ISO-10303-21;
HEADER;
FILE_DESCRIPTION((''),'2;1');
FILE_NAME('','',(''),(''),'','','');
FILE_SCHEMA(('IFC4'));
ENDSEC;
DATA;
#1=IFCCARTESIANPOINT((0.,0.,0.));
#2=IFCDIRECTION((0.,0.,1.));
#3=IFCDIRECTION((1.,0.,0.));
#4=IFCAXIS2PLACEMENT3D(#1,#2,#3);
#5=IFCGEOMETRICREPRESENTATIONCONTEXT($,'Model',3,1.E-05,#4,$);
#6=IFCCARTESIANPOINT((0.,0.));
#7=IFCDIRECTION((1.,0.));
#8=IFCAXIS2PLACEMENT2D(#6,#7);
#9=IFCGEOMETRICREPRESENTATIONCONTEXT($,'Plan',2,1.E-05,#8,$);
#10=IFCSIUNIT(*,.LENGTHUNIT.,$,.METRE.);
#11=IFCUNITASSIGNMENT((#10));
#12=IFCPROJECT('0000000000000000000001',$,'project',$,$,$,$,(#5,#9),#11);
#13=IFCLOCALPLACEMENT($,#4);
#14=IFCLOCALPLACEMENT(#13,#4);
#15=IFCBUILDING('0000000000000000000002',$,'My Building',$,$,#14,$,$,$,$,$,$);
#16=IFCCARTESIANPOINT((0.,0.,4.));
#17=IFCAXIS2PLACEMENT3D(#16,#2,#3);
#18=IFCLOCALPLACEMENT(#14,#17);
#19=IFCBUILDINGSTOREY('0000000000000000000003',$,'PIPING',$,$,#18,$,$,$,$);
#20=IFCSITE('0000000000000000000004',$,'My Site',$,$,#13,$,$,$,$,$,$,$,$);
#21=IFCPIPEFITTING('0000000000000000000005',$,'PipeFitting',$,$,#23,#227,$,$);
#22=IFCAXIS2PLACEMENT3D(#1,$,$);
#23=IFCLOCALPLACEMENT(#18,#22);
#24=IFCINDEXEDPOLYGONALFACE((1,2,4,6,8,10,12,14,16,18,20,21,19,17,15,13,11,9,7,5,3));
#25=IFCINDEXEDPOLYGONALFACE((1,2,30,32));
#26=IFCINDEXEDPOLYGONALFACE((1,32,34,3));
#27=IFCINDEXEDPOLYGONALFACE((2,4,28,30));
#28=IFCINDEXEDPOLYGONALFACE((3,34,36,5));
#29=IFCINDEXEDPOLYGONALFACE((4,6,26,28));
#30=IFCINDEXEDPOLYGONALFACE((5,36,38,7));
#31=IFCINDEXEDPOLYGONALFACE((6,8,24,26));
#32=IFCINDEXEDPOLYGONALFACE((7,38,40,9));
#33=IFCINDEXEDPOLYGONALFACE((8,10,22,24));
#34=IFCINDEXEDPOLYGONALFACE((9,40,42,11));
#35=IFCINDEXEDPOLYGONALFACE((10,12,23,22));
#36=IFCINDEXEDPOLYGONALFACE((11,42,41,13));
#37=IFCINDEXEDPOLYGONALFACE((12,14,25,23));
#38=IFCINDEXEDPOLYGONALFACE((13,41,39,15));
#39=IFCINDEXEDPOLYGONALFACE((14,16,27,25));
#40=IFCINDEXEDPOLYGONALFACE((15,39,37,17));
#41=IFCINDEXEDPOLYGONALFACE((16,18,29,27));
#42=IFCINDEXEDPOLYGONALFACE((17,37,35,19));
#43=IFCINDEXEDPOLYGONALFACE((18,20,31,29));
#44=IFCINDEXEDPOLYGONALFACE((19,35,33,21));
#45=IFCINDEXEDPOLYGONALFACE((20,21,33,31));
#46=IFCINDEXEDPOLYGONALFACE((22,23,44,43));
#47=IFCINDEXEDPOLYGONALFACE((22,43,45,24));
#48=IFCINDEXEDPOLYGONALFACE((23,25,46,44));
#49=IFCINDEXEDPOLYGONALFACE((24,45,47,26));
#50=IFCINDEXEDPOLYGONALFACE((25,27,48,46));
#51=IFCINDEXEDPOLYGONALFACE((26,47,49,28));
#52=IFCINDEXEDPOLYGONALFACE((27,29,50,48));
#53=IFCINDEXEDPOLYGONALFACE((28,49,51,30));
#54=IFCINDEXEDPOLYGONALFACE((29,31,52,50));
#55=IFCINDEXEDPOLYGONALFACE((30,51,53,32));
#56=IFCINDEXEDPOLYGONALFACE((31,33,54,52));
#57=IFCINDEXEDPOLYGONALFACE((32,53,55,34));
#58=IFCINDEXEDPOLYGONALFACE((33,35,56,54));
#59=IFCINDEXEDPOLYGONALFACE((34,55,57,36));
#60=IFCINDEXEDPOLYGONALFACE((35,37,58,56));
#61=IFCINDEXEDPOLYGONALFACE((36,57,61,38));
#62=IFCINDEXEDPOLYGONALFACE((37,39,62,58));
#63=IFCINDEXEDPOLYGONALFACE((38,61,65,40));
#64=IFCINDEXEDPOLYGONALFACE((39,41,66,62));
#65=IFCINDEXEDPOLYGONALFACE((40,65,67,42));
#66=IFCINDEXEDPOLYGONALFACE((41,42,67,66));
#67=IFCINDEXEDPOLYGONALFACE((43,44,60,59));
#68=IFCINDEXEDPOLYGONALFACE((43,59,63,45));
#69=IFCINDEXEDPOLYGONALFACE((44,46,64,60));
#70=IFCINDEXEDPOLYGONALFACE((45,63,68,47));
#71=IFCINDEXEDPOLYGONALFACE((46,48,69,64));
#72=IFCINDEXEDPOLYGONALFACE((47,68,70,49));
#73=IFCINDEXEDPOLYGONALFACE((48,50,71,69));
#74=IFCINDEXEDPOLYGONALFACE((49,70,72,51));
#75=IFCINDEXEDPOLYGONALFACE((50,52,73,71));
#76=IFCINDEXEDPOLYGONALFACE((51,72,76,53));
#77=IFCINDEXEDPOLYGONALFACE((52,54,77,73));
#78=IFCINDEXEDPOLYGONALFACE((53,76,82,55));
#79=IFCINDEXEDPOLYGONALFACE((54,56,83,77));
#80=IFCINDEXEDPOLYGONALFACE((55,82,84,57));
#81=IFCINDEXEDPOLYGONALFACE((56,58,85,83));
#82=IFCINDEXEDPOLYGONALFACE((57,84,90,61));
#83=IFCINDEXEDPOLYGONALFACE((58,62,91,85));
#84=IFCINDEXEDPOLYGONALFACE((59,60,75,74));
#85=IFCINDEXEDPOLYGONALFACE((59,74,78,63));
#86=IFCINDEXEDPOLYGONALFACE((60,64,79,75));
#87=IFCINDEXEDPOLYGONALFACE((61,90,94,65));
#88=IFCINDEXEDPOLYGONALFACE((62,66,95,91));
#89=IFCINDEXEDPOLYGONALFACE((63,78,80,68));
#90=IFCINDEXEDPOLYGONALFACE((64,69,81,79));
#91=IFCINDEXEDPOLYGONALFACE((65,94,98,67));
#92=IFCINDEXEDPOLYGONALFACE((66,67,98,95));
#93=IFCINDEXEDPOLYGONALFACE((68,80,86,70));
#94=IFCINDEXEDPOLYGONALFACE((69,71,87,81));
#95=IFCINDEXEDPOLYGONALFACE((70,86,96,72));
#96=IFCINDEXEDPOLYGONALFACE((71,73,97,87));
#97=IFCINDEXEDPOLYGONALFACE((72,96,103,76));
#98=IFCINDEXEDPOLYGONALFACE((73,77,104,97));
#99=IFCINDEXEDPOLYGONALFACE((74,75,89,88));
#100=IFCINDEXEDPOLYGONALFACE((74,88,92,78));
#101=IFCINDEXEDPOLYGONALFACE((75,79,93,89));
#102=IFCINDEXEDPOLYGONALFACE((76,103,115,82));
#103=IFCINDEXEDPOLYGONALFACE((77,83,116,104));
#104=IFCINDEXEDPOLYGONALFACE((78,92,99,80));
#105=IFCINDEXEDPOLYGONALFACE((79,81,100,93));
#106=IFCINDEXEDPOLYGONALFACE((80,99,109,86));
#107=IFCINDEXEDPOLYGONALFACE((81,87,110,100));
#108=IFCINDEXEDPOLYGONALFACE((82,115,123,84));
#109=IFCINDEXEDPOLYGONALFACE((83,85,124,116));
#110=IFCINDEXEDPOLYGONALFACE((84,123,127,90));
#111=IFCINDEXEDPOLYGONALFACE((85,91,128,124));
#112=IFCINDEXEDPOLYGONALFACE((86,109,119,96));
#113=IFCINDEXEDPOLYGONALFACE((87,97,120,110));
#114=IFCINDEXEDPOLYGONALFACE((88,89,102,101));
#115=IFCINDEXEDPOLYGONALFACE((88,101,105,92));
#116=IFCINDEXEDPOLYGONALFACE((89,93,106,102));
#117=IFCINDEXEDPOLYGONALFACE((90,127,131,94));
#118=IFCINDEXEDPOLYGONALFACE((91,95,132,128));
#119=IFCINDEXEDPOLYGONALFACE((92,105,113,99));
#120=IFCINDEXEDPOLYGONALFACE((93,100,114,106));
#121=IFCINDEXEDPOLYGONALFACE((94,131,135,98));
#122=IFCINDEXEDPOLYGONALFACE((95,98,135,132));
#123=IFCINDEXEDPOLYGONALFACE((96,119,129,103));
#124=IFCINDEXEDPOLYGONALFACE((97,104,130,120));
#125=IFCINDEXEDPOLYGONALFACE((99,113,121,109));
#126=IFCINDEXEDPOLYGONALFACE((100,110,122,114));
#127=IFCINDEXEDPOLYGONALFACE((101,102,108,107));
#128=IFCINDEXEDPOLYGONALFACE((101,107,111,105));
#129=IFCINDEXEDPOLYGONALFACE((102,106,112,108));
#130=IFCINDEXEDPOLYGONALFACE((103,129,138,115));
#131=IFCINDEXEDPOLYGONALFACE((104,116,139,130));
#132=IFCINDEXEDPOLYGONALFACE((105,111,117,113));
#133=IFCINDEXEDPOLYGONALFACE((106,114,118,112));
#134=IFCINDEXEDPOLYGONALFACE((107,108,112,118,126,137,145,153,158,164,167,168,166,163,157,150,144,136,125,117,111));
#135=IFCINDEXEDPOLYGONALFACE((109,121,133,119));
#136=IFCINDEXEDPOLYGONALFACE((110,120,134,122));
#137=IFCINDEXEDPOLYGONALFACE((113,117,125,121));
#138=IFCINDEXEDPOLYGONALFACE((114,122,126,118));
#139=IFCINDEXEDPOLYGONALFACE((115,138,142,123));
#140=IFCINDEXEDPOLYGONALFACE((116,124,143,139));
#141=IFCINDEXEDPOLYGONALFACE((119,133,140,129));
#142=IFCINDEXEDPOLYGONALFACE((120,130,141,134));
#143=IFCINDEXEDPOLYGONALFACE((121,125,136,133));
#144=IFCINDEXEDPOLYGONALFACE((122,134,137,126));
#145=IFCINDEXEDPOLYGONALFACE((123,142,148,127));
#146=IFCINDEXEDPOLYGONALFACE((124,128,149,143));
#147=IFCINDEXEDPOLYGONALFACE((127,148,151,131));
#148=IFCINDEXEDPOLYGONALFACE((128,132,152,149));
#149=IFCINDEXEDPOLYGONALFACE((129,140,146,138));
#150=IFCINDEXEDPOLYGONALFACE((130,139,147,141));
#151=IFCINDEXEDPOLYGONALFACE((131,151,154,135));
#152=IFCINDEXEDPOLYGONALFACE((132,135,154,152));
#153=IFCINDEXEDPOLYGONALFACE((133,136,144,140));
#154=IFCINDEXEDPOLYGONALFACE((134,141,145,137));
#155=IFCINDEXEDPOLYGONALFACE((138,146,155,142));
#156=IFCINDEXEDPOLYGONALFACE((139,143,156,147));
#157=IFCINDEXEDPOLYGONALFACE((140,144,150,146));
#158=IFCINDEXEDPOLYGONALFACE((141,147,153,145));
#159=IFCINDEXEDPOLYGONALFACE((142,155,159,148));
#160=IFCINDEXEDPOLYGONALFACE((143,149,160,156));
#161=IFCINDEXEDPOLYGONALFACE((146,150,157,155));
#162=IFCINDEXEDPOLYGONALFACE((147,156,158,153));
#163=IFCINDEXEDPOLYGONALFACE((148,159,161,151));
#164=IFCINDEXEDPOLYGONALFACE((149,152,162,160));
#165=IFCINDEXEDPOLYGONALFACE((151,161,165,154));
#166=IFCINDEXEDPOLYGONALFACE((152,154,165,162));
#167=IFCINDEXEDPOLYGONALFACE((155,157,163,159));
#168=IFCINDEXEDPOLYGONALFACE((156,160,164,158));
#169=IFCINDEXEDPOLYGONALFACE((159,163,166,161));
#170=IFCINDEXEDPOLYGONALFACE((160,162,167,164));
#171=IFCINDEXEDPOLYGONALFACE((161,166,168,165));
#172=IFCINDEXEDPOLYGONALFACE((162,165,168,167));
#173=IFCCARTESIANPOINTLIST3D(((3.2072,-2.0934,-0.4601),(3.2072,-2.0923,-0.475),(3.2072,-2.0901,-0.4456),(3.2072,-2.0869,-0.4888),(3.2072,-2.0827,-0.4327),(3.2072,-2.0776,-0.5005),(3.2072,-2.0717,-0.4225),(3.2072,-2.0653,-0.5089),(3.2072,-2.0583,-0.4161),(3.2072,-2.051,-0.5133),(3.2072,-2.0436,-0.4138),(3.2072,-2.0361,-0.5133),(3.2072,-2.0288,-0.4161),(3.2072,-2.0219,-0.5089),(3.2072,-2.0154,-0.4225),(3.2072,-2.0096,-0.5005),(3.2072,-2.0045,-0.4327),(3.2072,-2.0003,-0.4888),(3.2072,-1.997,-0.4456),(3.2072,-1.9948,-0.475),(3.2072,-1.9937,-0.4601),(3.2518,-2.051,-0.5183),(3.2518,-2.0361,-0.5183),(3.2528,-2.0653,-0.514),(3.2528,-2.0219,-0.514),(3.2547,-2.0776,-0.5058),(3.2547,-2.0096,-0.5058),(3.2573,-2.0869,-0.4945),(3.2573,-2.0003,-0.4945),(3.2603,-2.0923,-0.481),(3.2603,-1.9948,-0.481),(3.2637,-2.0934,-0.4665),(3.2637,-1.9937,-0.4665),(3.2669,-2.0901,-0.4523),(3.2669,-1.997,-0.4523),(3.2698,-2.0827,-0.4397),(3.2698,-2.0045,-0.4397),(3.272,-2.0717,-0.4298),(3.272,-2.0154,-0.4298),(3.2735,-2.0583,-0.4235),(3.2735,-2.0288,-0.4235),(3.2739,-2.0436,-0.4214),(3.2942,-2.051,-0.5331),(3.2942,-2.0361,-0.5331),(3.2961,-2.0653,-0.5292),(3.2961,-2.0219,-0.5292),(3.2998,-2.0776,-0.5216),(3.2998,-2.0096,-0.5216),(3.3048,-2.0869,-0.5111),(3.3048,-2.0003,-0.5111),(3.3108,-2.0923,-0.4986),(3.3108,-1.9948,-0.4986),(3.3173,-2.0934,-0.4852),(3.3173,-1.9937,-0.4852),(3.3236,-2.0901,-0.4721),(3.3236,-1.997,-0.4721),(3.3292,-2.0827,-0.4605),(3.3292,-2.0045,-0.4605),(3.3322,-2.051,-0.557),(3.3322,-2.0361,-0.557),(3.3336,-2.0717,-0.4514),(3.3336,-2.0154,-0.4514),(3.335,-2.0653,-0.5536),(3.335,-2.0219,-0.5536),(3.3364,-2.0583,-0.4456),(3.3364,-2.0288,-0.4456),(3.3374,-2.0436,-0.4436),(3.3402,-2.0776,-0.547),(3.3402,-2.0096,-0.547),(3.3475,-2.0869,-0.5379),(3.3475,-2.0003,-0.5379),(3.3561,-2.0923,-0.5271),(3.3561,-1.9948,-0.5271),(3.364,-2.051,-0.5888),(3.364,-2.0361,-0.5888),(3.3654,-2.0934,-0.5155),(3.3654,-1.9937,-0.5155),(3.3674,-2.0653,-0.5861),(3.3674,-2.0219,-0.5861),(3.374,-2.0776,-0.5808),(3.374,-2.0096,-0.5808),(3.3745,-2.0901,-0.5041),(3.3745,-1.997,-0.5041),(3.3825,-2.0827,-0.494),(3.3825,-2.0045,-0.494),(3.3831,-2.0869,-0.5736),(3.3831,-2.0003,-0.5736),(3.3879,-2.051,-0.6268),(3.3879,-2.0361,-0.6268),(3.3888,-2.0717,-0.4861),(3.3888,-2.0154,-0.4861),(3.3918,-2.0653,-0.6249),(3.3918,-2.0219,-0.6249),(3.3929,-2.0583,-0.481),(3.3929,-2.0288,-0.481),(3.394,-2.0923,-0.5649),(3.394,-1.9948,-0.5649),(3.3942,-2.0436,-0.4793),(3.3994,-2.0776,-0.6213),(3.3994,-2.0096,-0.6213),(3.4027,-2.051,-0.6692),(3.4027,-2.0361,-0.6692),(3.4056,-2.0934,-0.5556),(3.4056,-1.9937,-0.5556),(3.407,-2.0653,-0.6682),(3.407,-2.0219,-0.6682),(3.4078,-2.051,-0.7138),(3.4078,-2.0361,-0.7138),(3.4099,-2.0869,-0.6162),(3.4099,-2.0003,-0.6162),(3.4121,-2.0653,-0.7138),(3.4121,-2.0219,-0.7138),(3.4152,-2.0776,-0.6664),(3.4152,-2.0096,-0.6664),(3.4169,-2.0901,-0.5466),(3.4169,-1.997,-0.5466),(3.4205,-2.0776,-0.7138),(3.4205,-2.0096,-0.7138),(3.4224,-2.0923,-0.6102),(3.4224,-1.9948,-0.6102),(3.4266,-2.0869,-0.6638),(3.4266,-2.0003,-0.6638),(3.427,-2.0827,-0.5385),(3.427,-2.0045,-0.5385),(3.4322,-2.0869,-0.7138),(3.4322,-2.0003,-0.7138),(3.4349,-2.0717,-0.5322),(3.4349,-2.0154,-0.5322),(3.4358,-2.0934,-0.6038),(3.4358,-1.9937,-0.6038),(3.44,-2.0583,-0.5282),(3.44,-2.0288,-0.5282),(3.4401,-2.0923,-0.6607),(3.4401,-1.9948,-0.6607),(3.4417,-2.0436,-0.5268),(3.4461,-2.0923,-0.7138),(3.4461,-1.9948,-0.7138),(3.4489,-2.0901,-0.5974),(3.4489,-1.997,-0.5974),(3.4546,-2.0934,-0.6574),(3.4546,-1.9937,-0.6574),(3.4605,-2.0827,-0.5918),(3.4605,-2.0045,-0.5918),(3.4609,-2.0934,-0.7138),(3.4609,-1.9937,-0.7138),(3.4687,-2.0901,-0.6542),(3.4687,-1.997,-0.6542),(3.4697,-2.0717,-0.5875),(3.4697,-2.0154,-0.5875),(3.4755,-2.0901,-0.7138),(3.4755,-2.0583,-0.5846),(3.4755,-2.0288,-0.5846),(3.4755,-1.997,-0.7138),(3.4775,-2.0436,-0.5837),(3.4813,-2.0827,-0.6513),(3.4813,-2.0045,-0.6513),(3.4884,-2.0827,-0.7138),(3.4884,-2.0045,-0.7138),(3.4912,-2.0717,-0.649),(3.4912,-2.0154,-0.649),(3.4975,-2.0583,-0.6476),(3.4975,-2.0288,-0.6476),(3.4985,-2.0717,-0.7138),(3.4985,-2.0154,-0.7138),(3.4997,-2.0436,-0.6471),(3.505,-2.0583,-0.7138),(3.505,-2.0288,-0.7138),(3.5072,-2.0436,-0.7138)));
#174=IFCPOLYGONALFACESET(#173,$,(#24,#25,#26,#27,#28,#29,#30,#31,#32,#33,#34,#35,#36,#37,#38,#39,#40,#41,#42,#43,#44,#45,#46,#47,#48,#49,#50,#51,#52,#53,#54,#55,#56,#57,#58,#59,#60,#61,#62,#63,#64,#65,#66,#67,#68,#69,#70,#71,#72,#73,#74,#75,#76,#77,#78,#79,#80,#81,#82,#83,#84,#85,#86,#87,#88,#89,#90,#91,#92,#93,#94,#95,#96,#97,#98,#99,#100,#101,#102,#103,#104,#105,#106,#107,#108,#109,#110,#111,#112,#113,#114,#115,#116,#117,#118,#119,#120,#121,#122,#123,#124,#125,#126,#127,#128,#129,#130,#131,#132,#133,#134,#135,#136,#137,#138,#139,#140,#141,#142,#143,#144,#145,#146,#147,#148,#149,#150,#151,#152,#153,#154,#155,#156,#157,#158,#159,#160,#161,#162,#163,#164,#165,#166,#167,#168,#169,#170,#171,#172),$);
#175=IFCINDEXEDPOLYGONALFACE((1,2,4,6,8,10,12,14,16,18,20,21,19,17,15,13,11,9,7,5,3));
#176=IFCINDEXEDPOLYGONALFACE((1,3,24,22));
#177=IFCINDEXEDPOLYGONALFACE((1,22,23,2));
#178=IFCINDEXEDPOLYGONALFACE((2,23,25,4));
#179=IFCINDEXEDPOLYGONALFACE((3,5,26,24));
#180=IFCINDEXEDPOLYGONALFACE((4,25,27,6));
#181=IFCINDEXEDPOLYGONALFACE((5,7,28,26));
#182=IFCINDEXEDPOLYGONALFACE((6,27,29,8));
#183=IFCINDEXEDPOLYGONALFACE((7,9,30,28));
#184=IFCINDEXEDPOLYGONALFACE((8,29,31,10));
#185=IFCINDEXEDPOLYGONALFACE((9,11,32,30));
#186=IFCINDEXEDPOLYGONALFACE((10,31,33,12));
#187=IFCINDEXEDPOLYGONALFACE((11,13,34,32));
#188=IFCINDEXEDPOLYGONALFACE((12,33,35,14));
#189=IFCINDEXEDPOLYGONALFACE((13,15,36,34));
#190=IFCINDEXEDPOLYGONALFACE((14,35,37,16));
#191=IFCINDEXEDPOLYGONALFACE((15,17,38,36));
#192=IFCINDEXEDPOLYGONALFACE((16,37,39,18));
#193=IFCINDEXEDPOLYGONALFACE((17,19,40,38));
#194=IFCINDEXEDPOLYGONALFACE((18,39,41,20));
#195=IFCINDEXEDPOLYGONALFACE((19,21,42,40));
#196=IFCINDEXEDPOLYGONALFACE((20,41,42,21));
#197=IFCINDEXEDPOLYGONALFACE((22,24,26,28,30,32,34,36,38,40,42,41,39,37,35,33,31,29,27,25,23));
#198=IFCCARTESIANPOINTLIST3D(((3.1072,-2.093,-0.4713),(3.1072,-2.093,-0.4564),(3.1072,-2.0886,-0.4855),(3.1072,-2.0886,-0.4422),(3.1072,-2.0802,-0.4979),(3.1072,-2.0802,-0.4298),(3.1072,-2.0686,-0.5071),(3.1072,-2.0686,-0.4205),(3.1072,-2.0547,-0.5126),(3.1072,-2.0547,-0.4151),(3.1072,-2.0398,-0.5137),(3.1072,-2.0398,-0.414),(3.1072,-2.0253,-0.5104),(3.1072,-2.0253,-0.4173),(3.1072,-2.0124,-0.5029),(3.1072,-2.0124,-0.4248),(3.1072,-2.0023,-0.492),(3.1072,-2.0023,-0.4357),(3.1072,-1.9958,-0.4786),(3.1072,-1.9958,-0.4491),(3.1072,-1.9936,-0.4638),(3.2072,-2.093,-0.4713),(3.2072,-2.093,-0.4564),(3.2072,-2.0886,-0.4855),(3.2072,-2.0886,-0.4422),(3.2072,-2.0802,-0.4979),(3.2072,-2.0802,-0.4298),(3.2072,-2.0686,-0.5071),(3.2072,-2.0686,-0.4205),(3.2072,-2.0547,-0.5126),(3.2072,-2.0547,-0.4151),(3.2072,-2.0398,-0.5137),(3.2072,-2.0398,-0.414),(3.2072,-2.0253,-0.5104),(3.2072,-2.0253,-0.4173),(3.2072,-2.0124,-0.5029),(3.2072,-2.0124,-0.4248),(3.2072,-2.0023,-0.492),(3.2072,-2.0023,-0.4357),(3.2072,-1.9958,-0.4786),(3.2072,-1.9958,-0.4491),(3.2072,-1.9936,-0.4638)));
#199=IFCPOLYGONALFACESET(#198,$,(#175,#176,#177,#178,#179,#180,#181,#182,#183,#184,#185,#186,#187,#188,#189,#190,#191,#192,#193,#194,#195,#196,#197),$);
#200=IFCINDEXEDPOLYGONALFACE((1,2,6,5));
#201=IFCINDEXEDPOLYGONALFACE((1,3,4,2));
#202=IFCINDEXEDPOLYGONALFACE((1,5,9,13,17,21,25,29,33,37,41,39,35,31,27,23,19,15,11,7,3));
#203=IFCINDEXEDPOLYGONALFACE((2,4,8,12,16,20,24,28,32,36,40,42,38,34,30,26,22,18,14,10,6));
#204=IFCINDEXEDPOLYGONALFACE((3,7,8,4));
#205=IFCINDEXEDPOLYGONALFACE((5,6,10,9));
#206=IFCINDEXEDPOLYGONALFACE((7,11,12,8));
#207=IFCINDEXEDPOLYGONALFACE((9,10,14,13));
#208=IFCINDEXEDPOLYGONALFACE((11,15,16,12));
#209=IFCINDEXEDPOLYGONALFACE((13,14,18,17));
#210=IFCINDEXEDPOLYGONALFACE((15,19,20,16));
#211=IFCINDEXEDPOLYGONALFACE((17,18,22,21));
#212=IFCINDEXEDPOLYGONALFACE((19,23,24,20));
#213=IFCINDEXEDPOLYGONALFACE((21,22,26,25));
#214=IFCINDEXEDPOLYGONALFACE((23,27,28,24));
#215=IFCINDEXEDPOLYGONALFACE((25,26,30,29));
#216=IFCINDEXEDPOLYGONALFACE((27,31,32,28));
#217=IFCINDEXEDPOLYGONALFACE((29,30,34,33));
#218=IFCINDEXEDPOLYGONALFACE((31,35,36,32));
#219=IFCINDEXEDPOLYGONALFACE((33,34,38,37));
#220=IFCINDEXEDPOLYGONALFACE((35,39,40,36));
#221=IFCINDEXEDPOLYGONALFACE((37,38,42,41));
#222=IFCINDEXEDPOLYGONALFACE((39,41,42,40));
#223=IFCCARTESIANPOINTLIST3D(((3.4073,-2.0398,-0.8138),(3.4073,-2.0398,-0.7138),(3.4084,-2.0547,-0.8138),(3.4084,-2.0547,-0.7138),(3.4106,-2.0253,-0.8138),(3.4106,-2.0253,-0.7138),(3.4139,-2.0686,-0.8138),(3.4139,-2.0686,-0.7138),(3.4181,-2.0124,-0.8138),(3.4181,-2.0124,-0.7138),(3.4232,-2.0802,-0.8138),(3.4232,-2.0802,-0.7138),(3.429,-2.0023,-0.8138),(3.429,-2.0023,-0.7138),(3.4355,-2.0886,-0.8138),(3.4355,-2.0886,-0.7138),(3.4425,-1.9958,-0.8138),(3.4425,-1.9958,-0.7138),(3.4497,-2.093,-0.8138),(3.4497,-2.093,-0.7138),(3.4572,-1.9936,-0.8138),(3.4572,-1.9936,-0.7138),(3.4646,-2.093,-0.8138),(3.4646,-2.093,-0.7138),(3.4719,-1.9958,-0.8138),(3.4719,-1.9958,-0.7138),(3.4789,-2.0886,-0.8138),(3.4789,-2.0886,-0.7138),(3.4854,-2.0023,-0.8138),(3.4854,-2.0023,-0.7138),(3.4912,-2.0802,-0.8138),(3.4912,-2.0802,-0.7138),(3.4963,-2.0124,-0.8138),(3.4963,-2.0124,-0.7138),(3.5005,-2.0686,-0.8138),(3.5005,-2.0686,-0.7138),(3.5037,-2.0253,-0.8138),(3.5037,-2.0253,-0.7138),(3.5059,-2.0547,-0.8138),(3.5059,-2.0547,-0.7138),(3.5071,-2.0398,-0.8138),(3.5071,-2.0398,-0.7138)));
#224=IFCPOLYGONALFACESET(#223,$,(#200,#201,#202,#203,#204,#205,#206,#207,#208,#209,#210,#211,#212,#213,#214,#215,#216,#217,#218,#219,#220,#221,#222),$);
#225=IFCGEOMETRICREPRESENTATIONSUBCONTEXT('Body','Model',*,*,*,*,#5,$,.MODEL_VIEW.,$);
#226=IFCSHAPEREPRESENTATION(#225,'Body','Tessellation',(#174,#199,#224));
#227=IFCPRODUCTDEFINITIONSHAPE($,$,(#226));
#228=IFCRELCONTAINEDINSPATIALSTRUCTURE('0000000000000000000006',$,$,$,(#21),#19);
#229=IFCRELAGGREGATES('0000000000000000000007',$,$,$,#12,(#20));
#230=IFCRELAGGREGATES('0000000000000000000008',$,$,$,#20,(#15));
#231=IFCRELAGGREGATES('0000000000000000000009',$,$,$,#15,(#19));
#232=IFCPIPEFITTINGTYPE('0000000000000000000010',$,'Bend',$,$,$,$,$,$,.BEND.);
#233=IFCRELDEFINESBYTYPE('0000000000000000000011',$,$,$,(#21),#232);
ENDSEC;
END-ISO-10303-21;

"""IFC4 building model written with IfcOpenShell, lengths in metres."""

from ifc_helpers import new_model, entity, si_unit, frame, origin_with_axes, origin_2d_with_axis, place, context, subcontext, project, spatial, circle, extrude, source, transform, mapped, type_object, type_shapes, element, save


model = new_model("IFC4")

# Units and contexts
model_context = context("Model", 3, precision=1e-05, world=origin_with_axes())
plan_context = context("Plan", 2, precision=1e-05, world=origin_2d_with_axis())
body_context = subcontext(model_context, "Body", "Model", "MODEL_VIEW")
ifc_project = project(units=[si_unit("LENGTHUNIT", "METRE")], contexts=[model_context, plan_context])

# Site, building, storey
site_placement = place(None, origin_with_axes())
site = spatial("IfcSite", under=ifc_project, at=site_placement, Name="My Site")
building_placement = place(site_placement, origin_with_axes())
building = spatial("IfcBuilding", under=site, at=building_placement, Name="My Building")
storey_placement = place(building_placement, frame((0.0, 0.0, 4.0), z_axis=(0.0, 0.0, 1.0), x_axis=(1.0, 0.0, 0.0)))
storey = spatial("IfcBuildingStorey", under=building, at=storey_placement, Name="PIPING")

# Pipe fitting
pipe_fitting_type = type_object("IfcPipeFittingType", Name="Bend", PredefinedType="BEND")
shared_shape = source(origin_with_axes(), body_context, "Body", "SolidModel", [
    entity("IfcSweptDiskSolid", entity("IfcIndexedPolyCurve", entity("IfcCartesianPointList3D", [[0.0, 0.0, 0.1], [0.0, -0.0732, 0.2768], [0.0, -0.25, 0.35]]), [entity("IfcArcIndex", [1, 2, 3])]), 0.05),
    extrude(circle(Radius=0.05), origin_with_axes(), (0.0, 0.0, 1.0), 0.1),
    extrude(circle(Radius=0.05), frame((0.0, -0.25, 0.35), z_axis=(0.0, -1.0, 0.0), x_axis=(1.0, 0.0, 0.0)), (0.0, 0.0, 1.0), 0.1),
])
type_shapes(pipe_fitting_type, [shared_shape])
for number, where, z_axis, x_axis, name in (
    (1, (3.1072, -2.0436, -0.4638), (1.0, 0.0, 0.0), (0.0, 1.0, 0.0), "PipeFitting"),
):
    element("IfcPipeFitting", number, at=place(storey_placement, frame(where, z_axis=z_axis, x_axis=x_axis)), inside=storey, type_object=pipe_fitting_type, Name=name, context=body_context, shape_type="MappedRepresentation", body=[
        mapped(shared_shape, transform((0.0, 0.0, 0.0), x_axis=(1.0, 0.0, 0.0), y_axis=(0.0, 1.0, 0.0), z_axis=(0.0, 0.0, 1.0), scale=1.0)),
    ])

save(model, "model.ifc")
